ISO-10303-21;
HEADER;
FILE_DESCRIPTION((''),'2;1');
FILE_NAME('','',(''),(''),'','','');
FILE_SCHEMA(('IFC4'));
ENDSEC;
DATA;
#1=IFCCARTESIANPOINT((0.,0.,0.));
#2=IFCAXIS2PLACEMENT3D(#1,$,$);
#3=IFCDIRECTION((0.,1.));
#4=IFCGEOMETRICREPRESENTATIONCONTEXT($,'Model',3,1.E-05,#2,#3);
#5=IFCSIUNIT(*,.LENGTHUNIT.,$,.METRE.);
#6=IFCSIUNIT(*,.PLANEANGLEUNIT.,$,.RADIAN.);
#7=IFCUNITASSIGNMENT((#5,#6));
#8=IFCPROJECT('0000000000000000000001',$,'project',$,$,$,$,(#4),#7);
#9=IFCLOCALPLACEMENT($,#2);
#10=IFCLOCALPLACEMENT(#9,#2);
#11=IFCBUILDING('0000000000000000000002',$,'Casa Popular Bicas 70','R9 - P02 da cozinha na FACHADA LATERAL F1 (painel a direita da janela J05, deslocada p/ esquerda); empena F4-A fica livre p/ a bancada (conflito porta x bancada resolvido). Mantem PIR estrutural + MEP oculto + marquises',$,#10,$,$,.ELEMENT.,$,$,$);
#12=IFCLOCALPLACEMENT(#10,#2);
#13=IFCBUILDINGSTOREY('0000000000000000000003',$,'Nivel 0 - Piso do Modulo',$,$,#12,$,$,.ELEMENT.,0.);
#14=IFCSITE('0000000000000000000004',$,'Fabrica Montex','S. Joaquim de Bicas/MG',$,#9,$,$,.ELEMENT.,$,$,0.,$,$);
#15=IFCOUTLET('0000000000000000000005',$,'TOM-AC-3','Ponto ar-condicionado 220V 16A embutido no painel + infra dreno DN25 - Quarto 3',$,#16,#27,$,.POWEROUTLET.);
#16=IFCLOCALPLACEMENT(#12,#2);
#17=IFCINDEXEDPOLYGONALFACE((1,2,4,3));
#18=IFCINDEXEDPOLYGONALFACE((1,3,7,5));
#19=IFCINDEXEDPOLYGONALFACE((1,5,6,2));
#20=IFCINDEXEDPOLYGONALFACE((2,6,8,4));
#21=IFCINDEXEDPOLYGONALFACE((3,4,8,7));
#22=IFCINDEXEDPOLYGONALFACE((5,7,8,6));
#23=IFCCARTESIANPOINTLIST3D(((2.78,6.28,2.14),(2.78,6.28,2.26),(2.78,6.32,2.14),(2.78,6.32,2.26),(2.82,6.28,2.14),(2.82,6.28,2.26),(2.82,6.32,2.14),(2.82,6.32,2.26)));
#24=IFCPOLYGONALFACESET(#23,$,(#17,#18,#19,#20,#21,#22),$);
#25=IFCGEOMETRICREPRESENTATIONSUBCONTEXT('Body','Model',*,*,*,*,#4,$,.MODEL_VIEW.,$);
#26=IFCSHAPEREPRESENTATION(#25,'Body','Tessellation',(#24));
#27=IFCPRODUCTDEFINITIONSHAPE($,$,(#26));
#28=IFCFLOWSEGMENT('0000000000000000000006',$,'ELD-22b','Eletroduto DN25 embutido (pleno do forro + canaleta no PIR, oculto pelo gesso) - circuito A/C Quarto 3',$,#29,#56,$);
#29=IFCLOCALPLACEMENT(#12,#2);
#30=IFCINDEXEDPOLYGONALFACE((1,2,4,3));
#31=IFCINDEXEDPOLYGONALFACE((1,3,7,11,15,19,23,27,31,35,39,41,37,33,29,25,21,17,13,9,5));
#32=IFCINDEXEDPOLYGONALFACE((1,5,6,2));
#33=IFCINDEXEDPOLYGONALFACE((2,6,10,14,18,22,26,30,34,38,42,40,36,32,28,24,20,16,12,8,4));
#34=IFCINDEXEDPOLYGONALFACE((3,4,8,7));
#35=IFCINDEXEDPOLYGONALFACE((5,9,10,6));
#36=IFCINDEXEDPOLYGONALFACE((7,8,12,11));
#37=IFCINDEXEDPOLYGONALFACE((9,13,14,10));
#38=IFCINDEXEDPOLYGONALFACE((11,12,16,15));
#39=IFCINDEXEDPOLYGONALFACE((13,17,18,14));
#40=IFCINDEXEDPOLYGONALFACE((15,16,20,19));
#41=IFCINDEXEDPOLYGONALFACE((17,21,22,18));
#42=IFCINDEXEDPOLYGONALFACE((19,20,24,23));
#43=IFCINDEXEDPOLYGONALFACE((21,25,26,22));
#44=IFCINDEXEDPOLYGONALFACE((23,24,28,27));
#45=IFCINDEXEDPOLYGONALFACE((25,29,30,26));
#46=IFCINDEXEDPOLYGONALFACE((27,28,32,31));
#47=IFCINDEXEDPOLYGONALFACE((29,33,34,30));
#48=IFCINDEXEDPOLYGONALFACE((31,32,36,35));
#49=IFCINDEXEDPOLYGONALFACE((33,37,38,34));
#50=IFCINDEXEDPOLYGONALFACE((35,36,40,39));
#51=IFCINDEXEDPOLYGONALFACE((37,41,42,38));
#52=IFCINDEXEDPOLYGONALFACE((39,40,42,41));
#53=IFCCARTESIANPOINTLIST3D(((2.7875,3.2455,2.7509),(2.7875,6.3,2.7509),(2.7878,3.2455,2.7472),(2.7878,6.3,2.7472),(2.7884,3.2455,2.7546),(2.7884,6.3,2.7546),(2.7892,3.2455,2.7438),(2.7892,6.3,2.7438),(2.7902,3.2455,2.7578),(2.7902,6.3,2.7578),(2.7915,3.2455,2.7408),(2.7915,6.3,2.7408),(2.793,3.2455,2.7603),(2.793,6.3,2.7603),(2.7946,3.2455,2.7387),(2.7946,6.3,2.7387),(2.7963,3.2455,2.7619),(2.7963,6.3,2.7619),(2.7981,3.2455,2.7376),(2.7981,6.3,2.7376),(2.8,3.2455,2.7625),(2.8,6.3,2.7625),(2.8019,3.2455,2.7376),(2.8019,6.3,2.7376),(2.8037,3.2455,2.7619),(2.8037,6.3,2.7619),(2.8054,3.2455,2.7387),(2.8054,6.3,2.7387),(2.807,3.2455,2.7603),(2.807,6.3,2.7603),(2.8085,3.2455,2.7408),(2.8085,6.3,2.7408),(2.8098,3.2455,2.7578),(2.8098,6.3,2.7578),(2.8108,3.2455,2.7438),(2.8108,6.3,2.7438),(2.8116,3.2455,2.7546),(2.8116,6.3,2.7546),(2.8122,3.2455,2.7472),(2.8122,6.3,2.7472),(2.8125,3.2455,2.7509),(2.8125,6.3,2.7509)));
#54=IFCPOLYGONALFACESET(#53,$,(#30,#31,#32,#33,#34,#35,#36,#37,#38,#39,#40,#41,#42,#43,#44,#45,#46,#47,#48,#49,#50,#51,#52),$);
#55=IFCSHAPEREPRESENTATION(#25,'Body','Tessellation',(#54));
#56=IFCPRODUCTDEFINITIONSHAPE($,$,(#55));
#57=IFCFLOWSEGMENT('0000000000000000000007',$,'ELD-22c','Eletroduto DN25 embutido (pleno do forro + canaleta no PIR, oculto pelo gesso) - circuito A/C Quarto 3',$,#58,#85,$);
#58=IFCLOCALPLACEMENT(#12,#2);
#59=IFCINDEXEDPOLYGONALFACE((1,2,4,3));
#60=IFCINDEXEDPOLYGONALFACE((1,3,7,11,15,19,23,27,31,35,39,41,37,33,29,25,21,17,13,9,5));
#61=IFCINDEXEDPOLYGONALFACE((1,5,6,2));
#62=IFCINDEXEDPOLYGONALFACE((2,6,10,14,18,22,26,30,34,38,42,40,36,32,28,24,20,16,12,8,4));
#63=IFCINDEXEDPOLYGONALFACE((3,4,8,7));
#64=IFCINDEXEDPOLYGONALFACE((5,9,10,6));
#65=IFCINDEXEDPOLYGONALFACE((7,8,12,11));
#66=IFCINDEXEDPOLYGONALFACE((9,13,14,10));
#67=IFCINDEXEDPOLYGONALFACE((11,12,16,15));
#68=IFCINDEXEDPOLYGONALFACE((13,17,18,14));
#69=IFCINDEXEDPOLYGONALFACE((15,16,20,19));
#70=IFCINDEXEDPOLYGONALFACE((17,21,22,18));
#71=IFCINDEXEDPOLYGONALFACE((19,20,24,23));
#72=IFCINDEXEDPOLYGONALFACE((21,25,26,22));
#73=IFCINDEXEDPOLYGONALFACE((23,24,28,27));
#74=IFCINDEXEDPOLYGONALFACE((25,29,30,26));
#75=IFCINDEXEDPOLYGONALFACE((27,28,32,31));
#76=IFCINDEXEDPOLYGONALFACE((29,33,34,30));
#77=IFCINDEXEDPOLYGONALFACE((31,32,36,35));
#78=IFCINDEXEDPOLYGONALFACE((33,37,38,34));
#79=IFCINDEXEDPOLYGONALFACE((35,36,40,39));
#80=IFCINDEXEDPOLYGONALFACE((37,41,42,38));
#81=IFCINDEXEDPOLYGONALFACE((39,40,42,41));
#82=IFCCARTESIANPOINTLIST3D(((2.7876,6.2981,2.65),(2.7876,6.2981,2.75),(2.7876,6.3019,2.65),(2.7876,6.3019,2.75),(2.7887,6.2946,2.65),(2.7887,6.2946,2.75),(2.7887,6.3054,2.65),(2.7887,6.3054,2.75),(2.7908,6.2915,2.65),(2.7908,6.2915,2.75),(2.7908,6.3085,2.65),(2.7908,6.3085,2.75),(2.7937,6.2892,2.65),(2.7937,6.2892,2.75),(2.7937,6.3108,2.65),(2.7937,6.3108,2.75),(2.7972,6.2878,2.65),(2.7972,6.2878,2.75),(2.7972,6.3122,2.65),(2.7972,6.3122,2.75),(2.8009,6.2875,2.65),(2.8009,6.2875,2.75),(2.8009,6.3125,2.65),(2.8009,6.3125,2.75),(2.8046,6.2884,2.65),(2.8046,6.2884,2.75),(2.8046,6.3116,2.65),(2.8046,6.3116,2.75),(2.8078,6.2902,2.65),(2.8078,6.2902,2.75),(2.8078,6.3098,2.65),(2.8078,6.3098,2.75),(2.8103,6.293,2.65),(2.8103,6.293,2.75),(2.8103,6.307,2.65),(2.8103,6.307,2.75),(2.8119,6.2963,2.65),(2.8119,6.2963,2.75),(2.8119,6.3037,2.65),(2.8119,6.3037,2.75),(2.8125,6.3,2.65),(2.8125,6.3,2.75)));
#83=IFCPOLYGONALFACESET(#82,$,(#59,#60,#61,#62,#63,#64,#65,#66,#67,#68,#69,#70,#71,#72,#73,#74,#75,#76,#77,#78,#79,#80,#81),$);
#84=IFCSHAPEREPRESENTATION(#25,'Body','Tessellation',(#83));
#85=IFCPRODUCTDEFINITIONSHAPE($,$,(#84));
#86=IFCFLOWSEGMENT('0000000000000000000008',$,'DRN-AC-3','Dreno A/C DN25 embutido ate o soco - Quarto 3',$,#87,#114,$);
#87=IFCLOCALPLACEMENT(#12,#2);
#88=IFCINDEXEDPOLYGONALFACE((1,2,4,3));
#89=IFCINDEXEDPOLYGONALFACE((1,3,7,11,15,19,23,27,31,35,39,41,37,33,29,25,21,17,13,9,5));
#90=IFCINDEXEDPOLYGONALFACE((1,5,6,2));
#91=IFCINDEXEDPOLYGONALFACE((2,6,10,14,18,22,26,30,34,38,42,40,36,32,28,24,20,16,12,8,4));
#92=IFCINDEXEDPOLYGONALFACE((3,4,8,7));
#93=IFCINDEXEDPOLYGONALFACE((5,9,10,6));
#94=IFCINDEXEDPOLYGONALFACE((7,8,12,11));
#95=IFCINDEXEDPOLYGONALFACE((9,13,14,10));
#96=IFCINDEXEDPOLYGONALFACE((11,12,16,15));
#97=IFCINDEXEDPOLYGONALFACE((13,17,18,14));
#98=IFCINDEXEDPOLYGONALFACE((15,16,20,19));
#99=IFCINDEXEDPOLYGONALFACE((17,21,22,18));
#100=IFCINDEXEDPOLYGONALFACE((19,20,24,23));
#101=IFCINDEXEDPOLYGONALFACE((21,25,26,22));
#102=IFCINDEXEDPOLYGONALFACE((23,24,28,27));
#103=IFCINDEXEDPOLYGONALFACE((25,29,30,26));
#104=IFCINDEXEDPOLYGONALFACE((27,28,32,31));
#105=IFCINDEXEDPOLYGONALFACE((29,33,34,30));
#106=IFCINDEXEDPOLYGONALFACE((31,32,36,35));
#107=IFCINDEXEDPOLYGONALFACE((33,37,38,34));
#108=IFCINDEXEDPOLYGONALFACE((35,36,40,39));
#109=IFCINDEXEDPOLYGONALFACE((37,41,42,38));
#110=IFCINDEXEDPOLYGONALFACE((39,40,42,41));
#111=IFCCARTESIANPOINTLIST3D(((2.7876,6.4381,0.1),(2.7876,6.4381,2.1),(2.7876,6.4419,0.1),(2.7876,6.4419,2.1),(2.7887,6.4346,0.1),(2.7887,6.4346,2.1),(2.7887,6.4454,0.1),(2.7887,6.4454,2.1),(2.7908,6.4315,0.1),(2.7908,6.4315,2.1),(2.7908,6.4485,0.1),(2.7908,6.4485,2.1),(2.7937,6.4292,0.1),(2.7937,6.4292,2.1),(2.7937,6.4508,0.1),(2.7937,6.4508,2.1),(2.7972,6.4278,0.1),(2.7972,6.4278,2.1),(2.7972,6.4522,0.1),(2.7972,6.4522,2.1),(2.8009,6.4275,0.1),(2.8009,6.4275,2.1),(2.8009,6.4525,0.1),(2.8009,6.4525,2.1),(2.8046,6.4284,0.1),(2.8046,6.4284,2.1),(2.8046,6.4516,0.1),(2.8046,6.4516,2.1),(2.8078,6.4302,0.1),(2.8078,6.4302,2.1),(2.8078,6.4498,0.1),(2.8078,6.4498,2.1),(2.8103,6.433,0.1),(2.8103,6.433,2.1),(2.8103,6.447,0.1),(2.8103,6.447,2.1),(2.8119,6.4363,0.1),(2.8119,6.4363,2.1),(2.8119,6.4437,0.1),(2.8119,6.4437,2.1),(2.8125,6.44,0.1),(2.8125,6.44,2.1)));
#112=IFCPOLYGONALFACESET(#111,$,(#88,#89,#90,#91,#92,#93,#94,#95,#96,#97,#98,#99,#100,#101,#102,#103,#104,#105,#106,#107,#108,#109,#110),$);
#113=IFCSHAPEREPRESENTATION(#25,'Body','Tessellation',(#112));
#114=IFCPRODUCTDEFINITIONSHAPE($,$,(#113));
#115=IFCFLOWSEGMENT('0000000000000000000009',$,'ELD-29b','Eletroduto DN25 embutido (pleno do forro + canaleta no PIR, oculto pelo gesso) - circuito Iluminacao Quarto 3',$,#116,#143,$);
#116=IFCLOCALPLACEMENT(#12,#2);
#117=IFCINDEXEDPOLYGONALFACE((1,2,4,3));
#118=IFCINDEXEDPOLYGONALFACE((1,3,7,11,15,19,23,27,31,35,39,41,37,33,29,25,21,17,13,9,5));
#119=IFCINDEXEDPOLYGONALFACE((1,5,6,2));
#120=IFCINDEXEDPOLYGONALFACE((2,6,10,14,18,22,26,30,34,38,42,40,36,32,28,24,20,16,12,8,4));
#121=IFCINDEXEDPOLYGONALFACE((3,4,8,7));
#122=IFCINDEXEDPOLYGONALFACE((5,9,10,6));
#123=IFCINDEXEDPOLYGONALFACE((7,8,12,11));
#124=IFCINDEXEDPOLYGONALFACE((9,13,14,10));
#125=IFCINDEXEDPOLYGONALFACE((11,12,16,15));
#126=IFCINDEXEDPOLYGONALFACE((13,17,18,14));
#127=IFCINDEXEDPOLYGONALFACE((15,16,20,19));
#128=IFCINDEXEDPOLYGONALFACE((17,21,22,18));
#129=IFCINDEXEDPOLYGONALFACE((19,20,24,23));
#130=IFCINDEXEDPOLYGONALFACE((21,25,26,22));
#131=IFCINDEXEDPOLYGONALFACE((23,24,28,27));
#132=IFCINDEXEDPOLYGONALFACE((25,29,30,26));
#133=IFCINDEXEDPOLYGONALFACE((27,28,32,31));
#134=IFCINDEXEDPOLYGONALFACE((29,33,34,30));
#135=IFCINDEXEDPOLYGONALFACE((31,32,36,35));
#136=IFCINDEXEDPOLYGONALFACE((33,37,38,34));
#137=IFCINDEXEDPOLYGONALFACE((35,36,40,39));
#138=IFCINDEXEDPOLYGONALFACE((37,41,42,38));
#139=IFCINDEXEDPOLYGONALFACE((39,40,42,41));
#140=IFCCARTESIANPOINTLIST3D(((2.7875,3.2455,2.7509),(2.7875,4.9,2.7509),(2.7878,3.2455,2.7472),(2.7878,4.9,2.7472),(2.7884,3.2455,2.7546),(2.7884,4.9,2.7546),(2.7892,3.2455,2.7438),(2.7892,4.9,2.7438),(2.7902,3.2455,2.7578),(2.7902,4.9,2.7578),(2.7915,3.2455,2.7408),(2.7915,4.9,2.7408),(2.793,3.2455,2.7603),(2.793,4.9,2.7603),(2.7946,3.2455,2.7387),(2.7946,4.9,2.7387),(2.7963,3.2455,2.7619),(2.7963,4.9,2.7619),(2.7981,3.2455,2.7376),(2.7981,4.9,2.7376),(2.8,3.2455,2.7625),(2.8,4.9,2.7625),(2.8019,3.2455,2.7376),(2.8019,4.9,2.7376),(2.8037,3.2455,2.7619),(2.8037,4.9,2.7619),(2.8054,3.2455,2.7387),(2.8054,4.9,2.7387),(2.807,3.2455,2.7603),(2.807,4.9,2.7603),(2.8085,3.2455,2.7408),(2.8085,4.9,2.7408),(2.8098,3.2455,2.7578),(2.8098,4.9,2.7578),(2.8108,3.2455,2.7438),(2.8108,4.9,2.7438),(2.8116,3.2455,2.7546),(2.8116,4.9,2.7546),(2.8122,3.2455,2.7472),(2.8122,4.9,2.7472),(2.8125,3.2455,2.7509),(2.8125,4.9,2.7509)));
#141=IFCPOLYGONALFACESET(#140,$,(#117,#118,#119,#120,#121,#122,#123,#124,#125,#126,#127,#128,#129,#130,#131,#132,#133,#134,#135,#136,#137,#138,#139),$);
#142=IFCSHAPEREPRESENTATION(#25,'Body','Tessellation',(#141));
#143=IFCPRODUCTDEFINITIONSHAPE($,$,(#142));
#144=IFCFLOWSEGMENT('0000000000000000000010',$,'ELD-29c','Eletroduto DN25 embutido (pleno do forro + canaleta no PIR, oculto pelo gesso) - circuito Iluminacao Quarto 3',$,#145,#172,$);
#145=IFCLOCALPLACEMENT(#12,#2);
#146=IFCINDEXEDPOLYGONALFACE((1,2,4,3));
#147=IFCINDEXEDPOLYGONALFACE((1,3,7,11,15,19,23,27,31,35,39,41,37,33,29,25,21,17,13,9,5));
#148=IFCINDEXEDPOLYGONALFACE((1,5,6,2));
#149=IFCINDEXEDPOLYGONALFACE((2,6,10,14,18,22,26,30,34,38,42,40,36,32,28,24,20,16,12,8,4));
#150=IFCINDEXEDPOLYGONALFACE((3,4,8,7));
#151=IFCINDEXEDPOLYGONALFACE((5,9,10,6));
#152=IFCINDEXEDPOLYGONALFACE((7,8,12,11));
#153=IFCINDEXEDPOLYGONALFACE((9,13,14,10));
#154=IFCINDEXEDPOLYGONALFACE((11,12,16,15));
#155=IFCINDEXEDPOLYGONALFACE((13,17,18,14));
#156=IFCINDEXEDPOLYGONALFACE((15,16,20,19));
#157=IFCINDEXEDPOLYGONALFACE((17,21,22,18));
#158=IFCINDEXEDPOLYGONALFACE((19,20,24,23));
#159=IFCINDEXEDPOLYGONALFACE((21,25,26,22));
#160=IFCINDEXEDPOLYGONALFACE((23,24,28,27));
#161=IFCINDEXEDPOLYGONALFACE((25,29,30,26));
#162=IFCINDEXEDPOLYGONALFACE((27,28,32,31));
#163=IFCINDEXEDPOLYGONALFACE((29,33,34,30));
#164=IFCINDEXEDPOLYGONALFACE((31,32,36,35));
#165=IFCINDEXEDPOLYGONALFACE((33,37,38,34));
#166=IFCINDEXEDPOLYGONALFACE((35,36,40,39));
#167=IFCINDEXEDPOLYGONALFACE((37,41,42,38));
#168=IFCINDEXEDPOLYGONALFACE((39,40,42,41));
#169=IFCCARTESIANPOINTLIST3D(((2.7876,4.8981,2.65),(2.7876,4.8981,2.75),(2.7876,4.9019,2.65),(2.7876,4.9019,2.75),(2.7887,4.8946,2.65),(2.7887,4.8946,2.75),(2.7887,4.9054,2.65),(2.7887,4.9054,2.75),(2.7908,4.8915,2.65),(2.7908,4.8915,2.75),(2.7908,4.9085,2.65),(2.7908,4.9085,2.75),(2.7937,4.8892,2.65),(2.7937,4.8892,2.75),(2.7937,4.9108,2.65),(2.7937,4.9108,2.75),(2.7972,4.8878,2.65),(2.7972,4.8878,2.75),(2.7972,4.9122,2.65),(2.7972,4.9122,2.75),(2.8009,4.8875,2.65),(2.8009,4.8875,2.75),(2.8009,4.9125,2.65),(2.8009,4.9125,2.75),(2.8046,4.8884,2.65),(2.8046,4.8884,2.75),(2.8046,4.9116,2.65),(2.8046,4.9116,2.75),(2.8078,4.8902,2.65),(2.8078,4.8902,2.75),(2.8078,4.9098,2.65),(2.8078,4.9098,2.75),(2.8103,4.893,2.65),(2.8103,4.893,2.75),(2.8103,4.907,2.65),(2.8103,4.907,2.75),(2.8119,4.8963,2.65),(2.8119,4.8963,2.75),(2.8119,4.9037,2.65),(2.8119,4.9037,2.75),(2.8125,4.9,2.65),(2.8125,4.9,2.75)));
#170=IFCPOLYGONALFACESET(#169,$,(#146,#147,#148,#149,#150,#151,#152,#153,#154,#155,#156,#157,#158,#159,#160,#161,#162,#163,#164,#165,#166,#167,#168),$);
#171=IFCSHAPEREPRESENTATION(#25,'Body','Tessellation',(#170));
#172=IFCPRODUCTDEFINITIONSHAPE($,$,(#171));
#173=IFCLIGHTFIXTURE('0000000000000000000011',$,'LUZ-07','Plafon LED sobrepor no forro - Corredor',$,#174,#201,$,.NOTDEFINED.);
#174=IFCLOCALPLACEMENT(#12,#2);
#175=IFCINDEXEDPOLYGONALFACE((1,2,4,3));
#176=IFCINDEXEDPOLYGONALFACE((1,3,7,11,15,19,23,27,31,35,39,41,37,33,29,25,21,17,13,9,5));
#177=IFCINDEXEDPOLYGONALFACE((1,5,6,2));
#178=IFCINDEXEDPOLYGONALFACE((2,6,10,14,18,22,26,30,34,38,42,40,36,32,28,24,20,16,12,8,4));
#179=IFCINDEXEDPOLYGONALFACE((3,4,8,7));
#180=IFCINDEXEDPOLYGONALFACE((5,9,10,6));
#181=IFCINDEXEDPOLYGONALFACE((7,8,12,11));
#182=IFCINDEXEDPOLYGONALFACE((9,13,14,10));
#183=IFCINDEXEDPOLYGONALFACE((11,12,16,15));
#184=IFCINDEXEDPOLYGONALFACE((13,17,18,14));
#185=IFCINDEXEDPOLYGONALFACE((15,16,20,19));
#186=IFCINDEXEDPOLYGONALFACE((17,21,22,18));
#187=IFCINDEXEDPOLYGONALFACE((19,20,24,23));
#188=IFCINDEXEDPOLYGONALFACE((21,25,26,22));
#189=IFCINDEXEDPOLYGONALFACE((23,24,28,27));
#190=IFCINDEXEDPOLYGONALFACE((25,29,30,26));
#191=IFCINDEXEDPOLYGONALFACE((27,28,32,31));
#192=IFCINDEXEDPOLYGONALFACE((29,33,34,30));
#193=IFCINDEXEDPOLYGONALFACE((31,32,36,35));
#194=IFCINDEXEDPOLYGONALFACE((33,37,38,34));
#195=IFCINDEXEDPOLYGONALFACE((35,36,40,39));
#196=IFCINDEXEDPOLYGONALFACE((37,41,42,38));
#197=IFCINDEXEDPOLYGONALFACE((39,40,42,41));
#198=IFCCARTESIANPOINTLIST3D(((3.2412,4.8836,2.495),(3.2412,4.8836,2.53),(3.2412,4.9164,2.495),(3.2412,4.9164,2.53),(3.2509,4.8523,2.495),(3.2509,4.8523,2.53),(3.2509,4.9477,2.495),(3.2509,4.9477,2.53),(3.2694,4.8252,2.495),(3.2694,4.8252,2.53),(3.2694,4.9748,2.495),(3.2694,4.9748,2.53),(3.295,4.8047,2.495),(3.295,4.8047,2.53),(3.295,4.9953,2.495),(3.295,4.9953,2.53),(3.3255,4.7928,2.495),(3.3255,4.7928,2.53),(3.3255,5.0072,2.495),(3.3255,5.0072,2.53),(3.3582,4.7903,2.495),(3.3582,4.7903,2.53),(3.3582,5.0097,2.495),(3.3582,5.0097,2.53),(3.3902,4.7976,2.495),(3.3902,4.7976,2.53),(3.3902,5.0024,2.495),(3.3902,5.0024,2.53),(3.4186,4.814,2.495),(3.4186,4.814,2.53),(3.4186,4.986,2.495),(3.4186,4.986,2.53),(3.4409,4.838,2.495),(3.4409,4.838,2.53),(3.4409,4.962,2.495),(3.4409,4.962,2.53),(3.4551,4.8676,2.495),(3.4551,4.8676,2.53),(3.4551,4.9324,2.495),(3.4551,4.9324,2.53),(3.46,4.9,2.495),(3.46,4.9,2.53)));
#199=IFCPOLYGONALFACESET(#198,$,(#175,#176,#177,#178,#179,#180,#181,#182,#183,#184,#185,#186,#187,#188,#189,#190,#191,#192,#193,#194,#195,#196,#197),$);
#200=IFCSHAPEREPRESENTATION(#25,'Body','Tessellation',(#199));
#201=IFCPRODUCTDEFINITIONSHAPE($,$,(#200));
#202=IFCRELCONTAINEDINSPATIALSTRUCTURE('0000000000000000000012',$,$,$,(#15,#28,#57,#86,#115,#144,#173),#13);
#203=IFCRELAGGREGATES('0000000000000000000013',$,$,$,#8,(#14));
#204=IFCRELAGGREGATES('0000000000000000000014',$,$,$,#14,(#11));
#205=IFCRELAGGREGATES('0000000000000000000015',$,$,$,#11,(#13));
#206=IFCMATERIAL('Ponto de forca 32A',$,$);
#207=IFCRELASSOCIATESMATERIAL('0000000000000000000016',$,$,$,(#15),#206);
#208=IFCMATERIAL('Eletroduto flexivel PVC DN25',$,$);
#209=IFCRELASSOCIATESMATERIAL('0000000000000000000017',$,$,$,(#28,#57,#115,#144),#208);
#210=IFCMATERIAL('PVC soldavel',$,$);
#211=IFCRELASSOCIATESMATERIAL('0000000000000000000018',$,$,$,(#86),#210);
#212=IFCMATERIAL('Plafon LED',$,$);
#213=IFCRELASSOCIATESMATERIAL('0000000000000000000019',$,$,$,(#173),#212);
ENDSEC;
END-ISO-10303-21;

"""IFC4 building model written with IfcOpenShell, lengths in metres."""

from ifc_helpers import new_model, si_unit, direction, frame, frame_2d, origin, origin_2d, place, context, subcontext, project, spatial, rectangle, circle, extrude, material, element, save


model = new_model("IFC4")

# Units and contexts
model_context = context("Model", 3, precision=1e-05, world=origin(), true_north=direction((0.0, 1.0)))
body_context = subcontext(model_context, "Body", "Model", "MODEL_VIEW")
ifc_project = project(units=[si_unit("LENGTHUNIT", "METRE"), si_unit("PLANEANGLEUNIT", "RADIAN")], contexts=[model_context])

# Site, building, storey
site_placement = place(None, origin())
site = spatial("IfcSite", under=ifc_project, at=site_placement, Name="Fabrica Montex", Description="S. Joaquim de Bicas/MG", CompositionType="ELEMENT", RefElevation=0.0)
building_placement = place(site_placement, origin())
building = spatial("IfcBuilding", under=site, at=building_placement, Name="Casa Popular Bicas 70", Description="R9 - P02 da cozinha na FACHADA LATERAL F1 (painel a direita da janela J05, deslocada p/ esquerda); empena F4-A fica livre p/ a bancada (conflito porta x bancada resolvido). Mantem PIR estrutural + MEP oculto + marquises", CompositionType="ELEMENT")
storey_placement = place(building_placement, origin())
storey = spatial("IfcBuildingStorey", under=building, at=storey_placement, Name="Nivel 0 - Piso do Modulo", CompositionType="ELEMENT", Elevation=0.0)

# Outlet
ifc_material_1 = material(Name="Ponto de forca 32A")
outlet_1_placement = place(storey_placement, frame((2.78, 6.28, 2.14)))
element("IfcOutlet", 1, at=outlet_1_placement, inside=storey, material=ifc_material_1, Name="TOM-AC-3", Description="Ponto ar-condicionado 220V 16A embutido no painel + infra dreno DN25 - Quarto 3", PredefinedType="POWEROUTLET", context=body_context, shape_type="SweptSolid", body=[
    extrude(rectangle(XDim=0.04, YDim=0.04, at=frame_2d((0.02, 0.02))), origin(), (0.0, 0.0, 1.0), 0.12),
])

# Flow segments
ifc_material_2 = material(Name="Eletroduto flexivel PVC DN25")
flow_segment_1_placement = place(storey_placement, frame((2.8, 3.2455, 2.75), z_axis=(0.0, 1.0, 0.0), x_axis=(0.0, 0.0, 1.0)))
element("IfcFlowSegment", 2, at=flow_segment_1_placement, inside=storey, material=ifc_material_2, Name="ELD-22b", Description="Eletroduto DN25 embutido (pleno do forro + canaleta no PIR, oculto pelo gesso) - circuito A/C Quarto 3", context=body_context, shape_type="SweptSolid", body=[
    extrude(circle(Radius=0.0125, at=origin_2d()), origin(), (0.0, 0.0, 1.0), 3.0545),
])
flow_segment_2_placement = place(storey_placement, frame((2.8, 6.3, 2.75), z_axis=(0.0, 0.0, -1.0), x_axis=(1.0, 0.0, 0.0)))
element("IfcFlowSegment", 3, at=flow_segment_2_placement, inside=storey, material=ifc_material_2, Name="ELD-22c", Description="Eletroduto DN25 embutido (pleno do forro + canaleta no PIR, oculto pelo gesso) - circuito A/C Quarto 3", context=body_context, shape_type="SweptSolid", body=[
    extrude(circle(Radius=0.0125, at=origin_2d()), origin(), (0.0, 0.0, 1.0), 0.1),
])
ifc_material_3 = material(Name="PVC soldavel")
flow_segment_3_placement = place(storey_placement, frame((2.8, 6.44, 2.1), z_axis=(0.0, 0.0, -1.0), x_axis=(1.0, 0.0, 0.0)))
element("IfcFlowSegment", 4, at=flow_segment_3_placement, inside=storey, material=ifc_material_3, Name="DRN-AC-3", Description="Dreno A/C DN25 embutido ate o soco - Quarto 3", context=body_context, shape_type="SweptSolid", body=[
    extrude(circle(Radius=0.0125, at=origin_2d()), origin(), (0.0, 0.0, 1.0), 2.0),
])
flow_segment_4_placement = place(storey_placement, frame((2.8, 3.2455, 2.75), z_axis=(0.0, 1.0, 0.0), x_axis=(0.0, 0.0, 1.0)))
element("IfcFlowSegment", 5, at=flow_segment_4_placement, inside=storey, material=ifc_material_2, Name="ELD-29b", Description="Eletroduto DN25 embutido (pleno do forro + canaleta no PIR, oculto pelo gesso) - circuito Iluminacao Quarto 3", context=body_context, shape_type="SweptSolid", body=[
    extrude(circle(Radius=0.0125, at=origin_2d()), origin(), (0.0, 0.0, 1.0), 1.6545),
])
flow_segment_5_placement = place(storey_placement, frame((2.8, 4.9, 2.75), z_axis=(0.0, 0.0, -1.0), x_axis=(1.0, 0.0, 0.0)))
element("IfcFlowSegment", 6, at=flow_segment_5_placement, inside=storey, material=ifc_material_2, Name="ELD-29c", Description="Eletroduto DN25 embutido (pleno do forro + canaleta no PIR, oculto pelo gesso) - circuito Iluminacao Quarto 3", context=body_context, shape_type="SweptSolid", body=[
    extrude(circle(Radius=0.0125, at=origin_2d()), origin(), (0.0, 0.0, 1.0), 0.1),
])

# Light fixture
ifc_material_4 = material(Name="Plafon LED")
light_fixture_placement = place(storey_placement, frame((3.35, 4.9, 2.495)))
element("IfcLightFixture", 7, at=light_fixture_placement, inside=storey, material=ifc_material_4, Name="LUZ-07", Description="Plafon LED sobrepor no forro - Corredor", PredefinedType="NOTDEFINED", context=body_context, shape_type="SweptSolid", body=[
    extrude(circle(Radius=0.11, at=origin_2d()), origin(), (0.0, 0.0, 1.0), 0.035),
])

save(model, "model.ifc")
